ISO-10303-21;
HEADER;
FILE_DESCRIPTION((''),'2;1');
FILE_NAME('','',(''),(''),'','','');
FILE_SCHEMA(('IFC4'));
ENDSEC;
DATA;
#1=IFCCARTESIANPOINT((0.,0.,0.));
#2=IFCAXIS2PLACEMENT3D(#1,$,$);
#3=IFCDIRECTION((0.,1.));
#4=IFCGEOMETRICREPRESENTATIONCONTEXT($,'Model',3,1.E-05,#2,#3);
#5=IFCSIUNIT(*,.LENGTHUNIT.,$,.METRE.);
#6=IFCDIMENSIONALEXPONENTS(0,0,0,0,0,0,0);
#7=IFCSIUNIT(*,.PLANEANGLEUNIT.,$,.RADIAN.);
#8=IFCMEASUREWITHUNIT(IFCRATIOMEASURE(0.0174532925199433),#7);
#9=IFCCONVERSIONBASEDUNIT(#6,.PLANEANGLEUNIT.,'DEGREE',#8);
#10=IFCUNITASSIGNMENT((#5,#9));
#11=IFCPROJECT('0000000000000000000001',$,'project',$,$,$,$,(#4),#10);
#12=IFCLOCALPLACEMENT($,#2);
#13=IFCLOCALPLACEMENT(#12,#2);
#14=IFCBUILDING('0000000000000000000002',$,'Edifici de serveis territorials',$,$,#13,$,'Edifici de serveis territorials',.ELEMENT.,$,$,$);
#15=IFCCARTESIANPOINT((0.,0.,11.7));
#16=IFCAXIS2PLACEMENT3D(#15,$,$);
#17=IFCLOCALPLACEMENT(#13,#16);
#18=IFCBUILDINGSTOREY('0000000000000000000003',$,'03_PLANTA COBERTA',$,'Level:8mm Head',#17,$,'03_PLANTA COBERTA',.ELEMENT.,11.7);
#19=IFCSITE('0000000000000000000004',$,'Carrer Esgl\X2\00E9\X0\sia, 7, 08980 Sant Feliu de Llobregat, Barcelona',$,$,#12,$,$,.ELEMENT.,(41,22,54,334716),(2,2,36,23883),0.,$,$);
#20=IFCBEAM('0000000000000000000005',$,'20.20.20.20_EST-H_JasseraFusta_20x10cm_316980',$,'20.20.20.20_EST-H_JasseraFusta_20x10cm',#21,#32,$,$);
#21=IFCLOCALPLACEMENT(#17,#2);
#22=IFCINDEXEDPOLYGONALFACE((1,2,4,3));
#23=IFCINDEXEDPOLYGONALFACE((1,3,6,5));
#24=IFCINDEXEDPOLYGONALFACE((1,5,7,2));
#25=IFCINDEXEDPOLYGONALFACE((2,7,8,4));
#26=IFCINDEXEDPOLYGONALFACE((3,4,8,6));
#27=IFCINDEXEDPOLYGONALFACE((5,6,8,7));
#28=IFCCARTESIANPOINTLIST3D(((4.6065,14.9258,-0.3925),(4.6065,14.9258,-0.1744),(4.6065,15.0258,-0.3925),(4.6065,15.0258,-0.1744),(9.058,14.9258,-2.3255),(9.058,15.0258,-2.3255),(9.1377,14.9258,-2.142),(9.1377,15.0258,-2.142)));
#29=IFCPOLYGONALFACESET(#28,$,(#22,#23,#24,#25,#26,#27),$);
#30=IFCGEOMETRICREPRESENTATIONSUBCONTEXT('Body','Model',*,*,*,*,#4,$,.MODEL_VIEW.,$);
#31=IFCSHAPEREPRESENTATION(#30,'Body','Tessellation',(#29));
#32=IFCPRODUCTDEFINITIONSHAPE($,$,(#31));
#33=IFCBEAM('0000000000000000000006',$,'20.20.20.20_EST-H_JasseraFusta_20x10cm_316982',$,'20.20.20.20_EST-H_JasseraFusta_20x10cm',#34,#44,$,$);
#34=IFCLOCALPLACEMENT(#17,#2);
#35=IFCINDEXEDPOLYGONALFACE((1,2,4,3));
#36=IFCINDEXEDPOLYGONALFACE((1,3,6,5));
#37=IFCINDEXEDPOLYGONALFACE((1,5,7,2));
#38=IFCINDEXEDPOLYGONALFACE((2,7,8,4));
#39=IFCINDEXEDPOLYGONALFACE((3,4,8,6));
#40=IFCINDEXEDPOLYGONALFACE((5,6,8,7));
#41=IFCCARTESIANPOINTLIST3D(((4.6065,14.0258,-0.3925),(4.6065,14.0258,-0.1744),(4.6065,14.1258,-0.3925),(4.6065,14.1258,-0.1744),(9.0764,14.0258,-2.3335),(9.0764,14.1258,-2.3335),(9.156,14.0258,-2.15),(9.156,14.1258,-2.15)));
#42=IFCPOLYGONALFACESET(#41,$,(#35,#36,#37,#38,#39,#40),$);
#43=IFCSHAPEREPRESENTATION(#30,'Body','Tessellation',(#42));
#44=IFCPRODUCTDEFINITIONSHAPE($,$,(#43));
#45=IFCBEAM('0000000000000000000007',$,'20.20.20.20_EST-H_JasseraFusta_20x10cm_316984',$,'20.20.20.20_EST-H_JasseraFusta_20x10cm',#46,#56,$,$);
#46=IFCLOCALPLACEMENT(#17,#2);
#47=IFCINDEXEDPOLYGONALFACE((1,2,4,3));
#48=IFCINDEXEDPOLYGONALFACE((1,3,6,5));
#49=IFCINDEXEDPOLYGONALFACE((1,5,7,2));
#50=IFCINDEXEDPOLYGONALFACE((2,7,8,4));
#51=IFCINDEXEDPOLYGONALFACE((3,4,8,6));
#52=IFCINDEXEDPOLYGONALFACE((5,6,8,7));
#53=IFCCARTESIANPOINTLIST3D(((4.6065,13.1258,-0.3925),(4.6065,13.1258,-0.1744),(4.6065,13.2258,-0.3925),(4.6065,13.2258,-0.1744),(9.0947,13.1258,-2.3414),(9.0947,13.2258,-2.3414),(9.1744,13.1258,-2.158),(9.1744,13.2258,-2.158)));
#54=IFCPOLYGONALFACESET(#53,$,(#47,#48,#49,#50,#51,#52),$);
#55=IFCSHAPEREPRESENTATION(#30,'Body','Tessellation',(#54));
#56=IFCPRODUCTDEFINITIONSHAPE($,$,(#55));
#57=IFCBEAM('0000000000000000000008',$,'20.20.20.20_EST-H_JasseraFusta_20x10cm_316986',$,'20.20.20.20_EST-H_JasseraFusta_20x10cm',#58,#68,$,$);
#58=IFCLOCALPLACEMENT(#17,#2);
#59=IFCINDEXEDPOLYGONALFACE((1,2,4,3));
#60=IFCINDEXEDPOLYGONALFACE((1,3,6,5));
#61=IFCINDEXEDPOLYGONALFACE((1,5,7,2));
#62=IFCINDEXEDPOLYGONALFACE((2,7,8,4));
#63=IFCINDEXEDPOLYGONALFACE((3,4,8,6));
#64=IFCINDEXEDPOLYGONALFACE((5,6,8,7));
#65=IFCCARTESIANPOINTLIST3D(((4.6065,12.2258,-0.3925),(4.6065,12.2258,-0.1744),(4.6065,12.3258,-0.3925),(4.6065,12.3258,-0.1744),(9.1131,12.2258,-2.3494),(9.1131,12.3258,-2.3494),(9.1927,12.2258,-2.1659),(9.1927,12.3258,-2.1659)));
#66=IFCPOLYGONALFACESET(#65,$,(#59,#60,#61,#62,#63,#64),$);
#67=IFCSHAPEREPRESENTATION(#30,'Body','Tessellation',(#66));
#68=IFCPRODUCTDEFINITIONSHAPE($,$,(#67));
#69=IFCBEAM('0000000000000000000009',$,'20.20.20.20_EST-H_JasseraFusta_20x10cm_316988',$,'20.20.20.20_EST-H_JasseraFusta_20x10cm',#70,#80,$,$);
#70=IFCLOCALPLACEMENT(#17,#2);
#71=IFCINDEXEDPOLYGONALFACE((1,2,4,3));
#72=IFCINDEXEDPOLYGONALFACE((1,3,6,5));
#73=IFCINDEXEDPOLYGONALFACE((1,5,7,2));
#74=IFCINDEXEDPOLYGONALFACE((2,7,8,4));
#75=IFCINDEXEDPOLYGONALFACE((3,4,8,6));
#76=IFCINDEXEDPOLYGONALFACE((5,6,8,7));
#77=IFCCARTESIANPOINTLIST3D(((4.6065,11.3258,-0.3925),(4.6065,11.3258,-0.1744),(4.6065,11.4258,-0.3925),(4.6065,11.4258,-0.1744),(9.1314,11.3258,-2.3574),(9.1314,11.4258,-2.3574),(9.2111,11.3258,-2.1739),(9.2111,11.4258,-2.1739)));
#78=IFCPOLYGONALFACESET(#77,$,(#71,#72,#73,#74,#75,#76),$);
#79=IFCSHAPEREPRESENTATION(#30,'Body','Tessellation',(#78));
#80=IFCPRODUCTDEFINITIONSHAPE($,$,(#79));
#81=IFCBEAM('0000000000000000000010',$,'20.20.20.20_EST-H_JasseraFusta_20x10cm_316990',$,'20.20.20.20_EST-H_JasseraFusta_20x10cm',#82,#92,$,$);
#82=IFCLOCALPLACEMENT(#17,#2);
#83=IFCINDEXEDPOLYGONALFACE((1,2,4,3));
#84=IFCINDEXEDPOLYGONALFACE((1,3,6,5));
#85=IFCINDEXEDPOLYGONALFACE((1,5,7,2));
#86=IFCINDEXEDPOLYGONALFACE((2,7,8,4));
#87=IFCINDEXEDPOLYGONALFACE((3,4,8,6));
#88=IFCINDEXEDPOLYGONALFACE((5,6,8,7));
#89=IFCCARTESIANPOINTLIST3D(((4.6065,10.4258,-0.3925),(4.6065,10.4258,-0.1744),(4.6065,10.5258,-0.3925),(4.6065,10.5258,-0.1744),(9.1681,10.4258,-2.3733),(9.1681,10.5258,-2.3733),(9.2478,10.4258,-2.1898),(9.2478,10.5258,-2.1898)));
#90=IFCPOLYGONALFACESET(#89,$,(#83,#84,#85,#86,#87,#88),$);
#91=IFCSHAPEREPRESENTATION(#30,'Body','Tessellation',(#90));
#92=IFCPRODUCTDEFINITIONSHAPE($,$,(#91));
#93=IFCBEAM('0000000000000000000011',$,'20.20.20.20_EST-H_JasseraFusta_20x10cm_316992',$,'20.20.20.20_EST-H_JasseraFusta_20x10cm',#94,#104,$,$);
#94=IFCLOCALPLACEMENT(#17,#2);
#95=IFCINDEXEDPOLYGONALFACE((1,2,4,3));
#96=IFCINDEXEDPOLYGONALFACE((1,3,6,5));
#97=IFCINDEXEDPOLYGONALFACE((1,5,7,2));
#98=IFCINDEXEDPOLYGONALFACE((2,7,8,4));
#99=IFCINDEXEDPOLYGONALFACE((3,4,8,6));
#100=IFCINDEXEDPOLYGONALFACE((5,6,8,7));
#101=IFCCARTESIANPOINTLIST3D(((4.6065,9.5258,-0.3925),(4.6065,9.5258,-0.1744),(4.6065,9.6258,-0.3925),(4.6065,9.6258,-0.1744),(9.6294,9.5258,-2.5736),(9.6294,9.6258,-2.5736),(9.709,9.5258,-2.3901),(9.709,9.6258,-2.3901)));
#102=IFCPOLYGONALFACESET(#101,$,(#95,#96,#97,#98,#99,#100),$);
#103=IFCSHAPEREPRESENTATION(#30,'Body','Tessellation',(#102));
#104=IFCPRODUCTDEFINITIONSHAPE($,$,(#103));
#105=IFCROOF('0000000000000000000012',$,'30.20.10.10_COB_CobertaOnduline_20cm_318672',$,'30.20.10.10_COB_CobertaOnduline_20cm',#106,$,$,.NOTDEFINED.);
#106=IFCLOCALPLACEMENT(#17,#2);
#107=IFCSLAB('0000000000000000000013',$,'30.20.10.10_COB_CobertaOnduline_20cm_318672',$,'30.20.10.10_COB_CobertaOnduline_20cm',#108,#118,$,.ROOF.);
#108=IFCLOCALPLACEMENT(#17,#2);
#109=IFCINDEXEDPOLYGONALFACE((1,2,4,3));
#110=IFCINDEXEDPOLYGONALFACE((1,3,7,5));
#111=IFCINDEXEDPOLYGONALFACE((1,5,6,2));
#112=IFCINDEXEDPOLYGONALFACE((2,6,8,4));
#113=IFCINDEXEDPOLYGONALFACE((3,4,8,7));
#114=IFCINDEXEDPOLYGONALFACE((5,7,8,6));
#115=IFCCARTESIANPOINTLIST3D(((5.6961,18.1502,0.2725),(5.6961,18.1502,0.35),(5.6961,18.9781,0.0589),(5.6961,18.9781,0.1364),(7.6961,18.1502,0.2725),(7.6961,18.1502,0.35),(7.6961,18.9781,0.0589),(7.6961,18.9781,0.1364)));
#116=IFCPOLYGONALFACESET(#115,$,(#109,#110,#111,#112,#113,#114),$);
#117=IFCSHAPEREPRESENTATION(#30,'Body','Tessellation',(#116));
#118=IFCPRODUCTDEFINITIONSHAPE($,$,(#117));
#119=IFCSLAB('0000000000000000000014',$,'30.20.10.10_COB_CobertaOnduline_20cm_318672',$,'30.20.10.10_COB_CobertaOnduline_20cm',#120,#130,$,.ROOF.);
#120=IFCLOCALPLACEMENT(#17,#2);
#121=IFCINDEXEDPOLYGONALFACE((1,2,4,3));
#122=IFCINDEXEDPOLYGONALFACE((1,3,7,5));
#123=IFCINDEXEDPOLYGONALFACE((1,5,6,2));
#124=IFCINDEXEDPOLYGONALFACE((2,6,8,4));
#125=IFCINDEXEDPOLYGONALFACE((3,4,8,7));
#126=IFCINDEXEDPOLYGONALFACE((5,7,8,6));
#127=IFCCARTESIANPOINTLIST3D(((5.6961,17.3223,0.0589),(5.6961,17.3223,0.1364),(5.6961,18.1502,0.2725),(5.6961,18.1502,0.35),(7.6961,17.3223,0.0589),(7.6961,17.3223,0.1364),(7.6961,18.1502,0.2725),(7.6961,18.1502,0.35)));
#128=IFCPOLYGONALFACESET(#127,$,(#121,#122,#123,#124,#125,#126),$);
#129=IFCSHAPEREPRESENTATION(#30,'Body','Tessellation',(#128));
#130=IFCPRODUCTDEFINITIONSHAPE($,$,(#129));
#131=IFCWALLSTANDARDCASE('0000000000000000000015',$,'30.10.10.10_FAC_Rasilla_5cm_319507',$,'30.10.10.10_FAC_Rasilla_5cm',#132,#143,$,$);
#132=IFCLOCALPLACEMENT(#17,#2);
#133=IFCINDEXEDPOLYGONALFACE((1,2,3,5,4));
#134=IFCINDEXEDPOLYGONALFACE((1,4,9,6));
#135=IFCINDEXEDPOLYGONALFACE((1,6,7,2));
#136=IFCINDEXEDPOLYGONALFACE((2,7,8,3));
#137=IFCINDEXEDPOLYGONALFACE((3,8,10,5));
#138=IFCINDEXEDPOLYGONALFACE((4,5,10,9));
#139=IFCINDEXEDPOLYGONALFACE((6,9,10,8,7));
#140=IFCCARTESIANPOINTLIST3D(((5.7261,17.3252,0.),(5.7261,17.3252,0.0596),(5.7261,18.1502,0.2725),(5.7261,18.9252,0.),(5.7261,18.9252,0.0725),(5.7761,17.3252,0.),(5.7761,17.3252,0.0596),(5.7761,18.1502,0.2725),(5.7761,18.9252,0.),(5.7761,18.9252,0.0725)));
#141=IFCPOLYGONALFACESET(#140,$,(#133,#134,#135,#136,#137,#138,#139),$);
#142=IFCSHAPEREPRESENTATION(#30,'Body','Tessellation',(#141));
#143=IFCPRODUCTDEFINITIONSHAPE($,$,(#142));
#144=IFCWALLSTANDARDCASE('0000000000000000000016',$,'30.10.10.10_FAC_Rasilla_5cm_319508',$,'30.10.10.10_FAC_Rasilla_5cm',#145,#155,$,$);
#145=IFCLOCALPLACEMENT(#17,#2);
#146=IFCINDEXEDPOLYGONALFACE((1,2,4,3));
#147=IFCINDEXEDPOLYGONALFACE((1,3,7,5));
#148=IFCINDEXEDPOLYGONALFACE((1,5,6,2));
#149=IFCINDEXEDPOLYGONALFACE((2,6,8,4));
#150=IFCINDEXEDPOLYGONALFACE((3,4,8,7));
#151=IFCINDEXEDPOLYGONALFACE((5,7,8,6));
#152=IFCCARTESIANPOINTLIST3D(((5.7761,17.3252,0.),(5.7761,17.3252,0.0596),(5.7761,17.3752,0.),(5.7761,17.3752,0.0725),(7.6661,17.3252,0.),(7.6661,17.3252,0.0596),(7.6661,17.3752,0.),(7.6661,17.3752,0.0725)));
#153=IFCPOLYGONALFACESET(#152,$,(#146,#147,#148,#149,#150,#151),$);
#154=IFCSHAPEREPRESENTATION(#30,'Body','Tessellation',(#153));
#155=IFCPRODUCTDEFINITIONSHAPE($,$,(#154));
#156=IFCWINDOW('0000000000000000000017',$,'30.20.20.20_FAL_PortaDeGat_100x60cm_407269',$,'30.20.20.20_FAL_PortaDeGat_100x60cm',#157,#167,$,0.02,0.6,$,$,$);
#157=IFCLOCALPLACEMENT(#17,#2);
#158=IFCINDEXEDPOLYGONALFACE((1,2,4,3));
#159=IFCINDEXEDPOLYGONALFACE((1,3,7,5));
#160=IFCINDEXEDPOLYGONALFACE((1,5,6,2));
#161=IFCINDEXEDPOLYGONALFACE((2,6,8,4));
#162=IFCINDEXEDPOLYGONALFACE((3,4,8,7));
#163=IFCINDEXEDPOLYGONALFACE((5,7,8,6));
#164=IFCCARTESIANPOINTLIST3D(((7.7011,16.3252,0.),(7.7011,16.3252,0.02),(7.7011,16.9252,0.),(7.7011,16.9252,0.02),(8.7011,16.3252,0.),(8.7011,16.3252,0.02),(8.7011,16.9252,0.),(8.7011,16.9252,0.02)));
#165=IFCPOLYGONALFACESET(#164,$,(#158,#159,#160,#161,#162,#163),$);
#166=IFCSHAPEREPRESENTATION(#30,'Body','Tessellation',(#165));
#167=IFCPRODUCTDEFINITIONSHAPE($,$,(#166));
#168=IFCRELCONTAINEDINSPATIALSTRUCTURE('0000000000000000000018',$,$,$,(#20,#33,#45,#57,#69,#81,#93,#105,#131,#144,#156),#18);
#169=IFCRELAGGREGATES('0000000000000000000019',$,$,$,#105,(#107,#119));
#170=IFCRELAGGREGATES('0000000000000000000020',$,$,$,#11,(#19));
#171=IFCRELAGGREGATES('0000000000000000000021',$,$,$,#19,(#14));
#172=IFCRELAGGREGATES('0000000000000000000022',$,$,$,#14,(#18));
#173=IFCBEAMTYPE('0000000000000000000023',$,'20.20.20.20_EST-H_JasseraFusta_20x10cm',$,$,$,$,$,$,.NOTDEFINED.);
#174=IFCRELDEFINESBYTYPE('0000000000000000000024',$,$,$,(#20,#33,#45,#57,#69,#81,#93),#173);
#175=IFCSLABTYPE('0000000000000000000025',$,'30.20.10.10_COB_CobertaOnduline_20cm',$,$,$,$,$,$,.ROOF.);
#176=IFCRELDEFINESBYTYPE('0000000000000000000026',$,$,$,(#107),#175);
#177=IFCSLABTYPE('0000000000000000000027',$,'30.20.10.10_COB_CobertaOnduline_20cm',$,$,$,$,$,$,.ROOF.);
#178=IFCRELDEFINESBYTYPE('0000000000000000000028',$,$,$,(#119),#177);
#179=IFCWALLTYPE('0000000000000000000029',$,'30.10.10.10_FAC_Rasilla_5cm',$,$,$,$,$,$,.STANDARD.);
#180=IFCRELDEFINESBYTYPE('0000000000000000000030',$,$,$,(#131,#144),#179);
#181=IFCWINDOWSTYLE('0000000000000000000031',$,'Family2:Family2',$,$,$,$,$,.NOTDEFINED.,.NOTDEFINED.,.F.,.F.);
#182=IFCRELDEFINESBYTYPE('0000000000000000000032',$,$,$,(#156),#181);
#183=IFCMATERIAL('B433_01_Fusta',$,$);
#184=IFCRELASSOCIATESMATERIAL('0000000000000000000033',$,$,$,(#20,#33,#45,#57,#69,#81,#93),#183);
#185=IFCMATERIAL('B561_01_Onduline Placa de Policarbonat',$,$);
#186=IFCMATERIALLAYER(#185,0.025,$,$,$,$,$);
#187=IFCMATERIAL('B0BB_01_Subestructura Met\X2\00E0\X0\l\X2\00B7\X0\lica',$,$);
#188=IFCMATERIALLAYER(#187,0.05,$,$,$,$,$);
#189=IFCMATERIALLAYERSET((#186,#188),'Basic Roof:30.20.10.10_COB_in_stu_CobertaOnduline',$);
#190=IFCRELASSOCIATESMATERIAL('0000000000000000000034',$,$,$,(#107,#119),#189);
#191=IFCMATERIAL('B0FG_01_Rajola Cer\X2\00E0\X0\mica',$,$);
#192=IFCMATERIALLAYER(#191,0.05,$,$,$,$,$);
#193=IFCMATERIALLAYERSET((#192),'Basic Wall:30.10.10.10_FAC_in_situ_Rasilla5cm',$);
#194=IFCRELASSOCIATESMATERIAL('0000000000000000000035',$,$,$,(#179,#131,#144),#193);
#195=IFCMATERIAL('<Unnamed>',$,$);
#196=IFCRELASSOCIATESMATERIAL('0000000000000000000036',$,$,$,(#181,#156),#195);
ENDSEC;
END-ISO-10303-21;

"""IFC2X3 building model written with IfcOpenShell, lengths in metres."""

from ifc_helpers import new_model, entity, si_unit, converted_unit, direction, frame, frame_2d, origin, origin_2d_with_axis, place, context, subcontext, project, spatial, polyline, rectangle, extrude, clip, halfspace, bounded_halfspace, source, transform, mapped, material, layer, layer_set, layer_usage, type_object, type_shapes, element, aggregate, save


model = new_model("IFC2X3")

# Units and contexts
model_context = context("Model", 3, precision=1e-05, world=origin(), true_north=direction((0.0, 1.0)))
body_context = subcontext(model_context, "Body", "Model", "MODEL_VIEW")
ifc_project = project(units=[si_unit("LENGTHUNIT", "METRE"), converted_unit("PLANEANGLEUNIT", "DEGREE", entity("IfcRatioMeasure", 0.0174532925199433), si_unit("PLANEANGLEUNIT", "RADIAN"), dimensions=[0, 0, 0, 0, 0, 0, 0])], contexts=[model_context])

# Site, building, storey
site_placement = place(None, origin())
site = spatial("IfcSite", under=ifc_project, at=site_placement, Name="Carrer Església, 7, 08980 Sant Feliu de Llobregat, Barcelona", CompositionType="ELEMENT", RefLatitude=(41, 22, 54, 334716), RefLongitude=(2, 2, 36, 23883), RefElevation=0.0)
building_placement = place(site_placement, origin())
building = spatial("IfcBuilding", under=site, at=building_placement, Name="Edifici de serveis territorials", LongName="Edifici de serveis territorials", CompositionType="ELEMENT")
storey_placement = place(building_placement, frame((0.0, 0.0, 11.7)))
storey = spatial("IfcBuildingStorey", under=building, at=storey_placement, Name="03_PLANTA COBERTA", ObjectType="Level:8mm Head", LongName="03_PLANTA COBERTA", CompositionType="ELEMENT", Elevation=11.7)

# Beams
ifc_material_1 = material(Name="B433_01_Fusta")
beam_type = type_object("IfcBeamType", Name="20.20.20.20_EST-H_JasseraFusta_20x10cm", PredefinedType="NOTDEFINED")
beam_1_placement = place(storey_placement, frame((4.6065, 14.9758, -0.1744), z_axis=(0.3983, 0.0, 0.917255), x_axis=(0.917255, 0.0, -0.3983)))
element("IfcBeam", 1, at=beam_1_placement, inside=storey, type_object=beam_type, material=ifc_material_1, Name="20.20.20.20_EST-H_JasseraFusta_20x10cm_316980", ObjectType="20.20.20.20_EST-H_JasseraFusta_20x10cm", context=body_context, shape_type="Clipping", body=[
    clip(extrude(rectangle(XDim=0.2, YDim=0.1, at=frame_2d((0.0, 0.0), x_axis=(1.0, 0.0))), frame((0.0, 0.0, -0.1), z_axis=(1.0, 0.0, 0.0), x_axis=(0.0, 0.0, -1.0)), (0.0, 0.0, 1.0), 4.94), halfspace(frame((0.0868, 0.0, -0.2), z_axis=(-0.917255, 0.0, -0.3983), x_axis=(0.0, 1.0, 0.0)), False)),
])
beam_2_placement = place(storey_placement, frame((4.6065, 14.0758, -0.1744), z_axis=(0.3983, 0.0, 0.917255), x_axis=(0.917255, 0.0, -0.3983)))
element("IfcBeam", 2, at=beam_2_placement, inside=storey, type_object=beam_type, material=ifc_material_1, Name="20.20.20.20_EST-H_JasseraFusta_20x10cm_316982", ObjectType="20.20.20.20_EST-H_JasseraFusta_20x10cm", context=body_context, shape_type="Clipping", body=[
    clip(extrude(rectangle(XDim=0.2, YDim=0.1, at=frame_2d((0.0, 0.0), x_axis=(1.0, 0.0))), frame((0.0, 0.0, -0.1), z_axis=(1.0, 0.0, 0.0), x_axis=(0.0, 0.0, -1.0)), (0.0, 0.0, 1.0), 4.96), halfspace(frame((0.0868, 0.0, -0.2), z_axis=(-0.917255, 0.0, -0.3983), x_axis=(0.0, 1.0, 0.0)), False)),
])
beam_3_placement = place(storey_placement, frame((4.6065, 13.1758, -0.1744), z_axis=(0.3983, 0.0, 0.917255), x_axis=(0.917255, 0.0, -0.3983)))
element("IfcBeam", 3, at=beam_3_placement, inside=storey, type_object=beam_type, material=ifc_material_1, Name="20.20.20.20_EST-H_JasseraFusta_20x10cm_316984", ObjectType="20.20.20.20_EST-H_JasseraFusta_20x10cm", context=body_context, shape_type="Clipping", body=[
    clip(extrude(rectangle(XDim=0.2, YDim=0.1, at=origin_2d_with_axis()), frame((0.0, 0.0, -0.1), z_axis=(1.0, 0.0, 0.0), x_axis=(0.0, 0.0, -1.0)), (0.0, 0.0, 1.0), 4.98), halfspace(frame((0.0868, 0.0, -0.2), z_axis=(-0.917255, 0.0, -0.3983), x_axis=(0.0, 1.0, 0.0)), False)),
])
beam_4_placement = place(storey_placement, frame((4.6065, 12.2758, -0.1744), z_axis=(0.3983, 0.0, 0.917255), x_axis=(0.917255, 0.0, -0.3983)))
element("IfcBeam", 4, at=beam_4_placement, inside=storey, type_object=beam_type, material=ifc_material_1, Name="20.20.20.20_EST-H_JasseraFusta_20x10cm_316986", ObjectType="20.20.20.20_EST-H_JasseraFusta_20x10cm", context=body_context, shape_type="Clipping", body=[
    clip(extrude(rectangle(XDim=0.2, YDim=0.1, at=frame_2d((0.0, 0.0), x_axis=(1.0, 0.0))), frame((0.0, 0.0, -0.1), z_axis=(1.0, 0.0, 0.0), x_axis=(0.0, 0.0, -1.0)), (0.0, 0.0, 1.0), 5.0), halfspace(frame((0.0868, 0.0, -0.2), z_axis=(-0.917255, 0.0, -0.3983), x_axis=(0.0, 1.0, 0.0)), False)),
])
beam_5_placement = place(storey_placement, frame((4.6065, 11.3758, -0.1744), z_axis=(0.3983, 0.0, 0.917255), x_axis=(0.917255, 0.0, -0.3983)))
element("IfcBeam", 5, at=beam_5_placement, inside=storey, type_object=beam_type, material=ifc_material_1, Name="20.20.20.20_EST-H_JasseraFusta_20x10cm_316988", ObjectType="20.20.20.20_EST-H_JasseraFusta_20x10cm", context=body_context, shape_type="Clipping", body=[
    clip(extrude(rectangle(XDim=0.2, YDim=0.1, at=origin_2d_with_axis()), frame((0.0, 0.0, -0.1), z_axis=(1.0, 0.0, 0.0), x_axis=(0.0, 0.0, -1.0)), (0.0, 0.0, 1.0), 5.02), halfspace(frame((0.0868, 0.0, -0.2), z_axis=(-0.917255, 0.0, -0.3983), x_axis=(0.0, 1.0, 0.0)), False)),
])
beam_6_placement = place(storey_placement, frame((4.6065, 10.4758, -0.1744), z_axis=(0.3983, 0.0, 0.917255), x_axis=(0.917255, 0.0, -0.3983)))
element("IfcBeam", 6, at=beam_6_placement, inside=storey, type_object=beam_type, material=ifc_material_1, Name="20.20.20.20_EST-H_JasseraFusta_20x10cm_316990", ObjectType="20.20.20.20_EST-H_JasseraFusta_20x10cm", context=body_context, shape_type="Clipping", body=[
    clip(extrude(rectangle(XDim=0.2, YDim=0.1, at=frame_2d((0.0, 0.0), x_axis=(1.0, 0.0))), frame((0.0, 0.0, -0.1), z_axis=(1.0, 0.0, 0.0), x_axis=(0.0, 0.0, -1.0)), (0.0, 0.0, 1.0), 5.06), halfspace(frame((0.0868, 0.0, -0.2), z_axis=(-0.917255, 0.0, -0.3983), x_axis=(0.0, 1.0, 0.0)), False)),
])
beam_7_placement = place(storey_placement, frame((4.6065, 9.5758, -0.1744), z_axis=(0.3983, 0.0, 0.917255), x_axis=(0.917255, 0.0, -0.3983)))
element("IfcBeam", 7, at=beam_7_placement, inside=storey, type_object=beam_type, material=ifc_material_1, Name="20.20.20.20_EST-H_JasseraFusta_20x10cm_316992", ObjectType="20.20.20.20_EST-H_JasseraFusta_20x10cm", context=body_context, shape_type="Clipping", body=[
    clip(extrude(rectangle(XDim=0.2, YDim=0.1, at=frame_2d((0.0, 0.0), x_axis=(1.0, 0.0))), frame((0.0, 0.0, -0.1), z_axis=(1.0, 0.0, 0.0), x_axis=(0.0, 0.0, -1.0)), (0.0, 0.0, 1.0), 5.5629), halfspace(frame((0.0868, 0.0, -0.2), z_axis=(-0.917255, 0.0, -0.3983), x_axis=(0.0, 1.0, 0.0)), False)),
])

# Shared definitions
ifc_material_2 = material(Name="B0FG_01_Rajola Ceràmica")

# Roof, slabs
roof_1_placement = place(storey_placement, frame((5.6961, 17.3223, 0.0589)))
roof_1 = element("IfcRoof", 8, at=roof_1_placement, inside=storey, Name="30.20.10.10_COB_CobertaOnduline_20cm_318672", ObjectType="30.20.10.10_COB_CobertaOnduline_20cm", ShapeType="NOTDEFINED")
ifc_material_3 = material(Name="B561_01_Onduline Placa de Policarbonat")
ifc_layer_1 = layer(ifc_material_3, 0.025)
ifc_material_4 = material(Name="B0BB_01_Subestructura Metàl·lica")
ifc_layer_2 = layer(ifc_material_4, 0.05)
ifc_layer_set_1 = layer_set([ifc_layer_1, ifc_layer_2], Name="Basic Roof:30.20.10.10_COB_in_stu_CobertaOnduline")
slab_type_1 = type_object("IfcSlabType", Name="30.20.10.10_COB_CobertaOnduline_20cm", PredefinedType="ROOF")
slab_1_placement = place(roof_1_placement, origin())
slab_1 = element("IfcSlab", 9, at=slab_1_placement, type_object=slab_type_1, material=ifc_layer_set_1, Name="30.20.10.10_COB_CobertaOnduline_20cm_318672", ObjectType="30.20.10.10_COB_CobertaOnduline_20cm", PredefinedType="ROOF", context=body_context, shape_type="SweptSolid", body=[
    extrude(rectangle(XDim=2.0, YDim=0.855, at=frame_2d((0.0, 0.0), x_axis=(1.0, 0.0))), frame((1.0, 1.2418, 0.1068), z_axis=(0.0, 0.249878, 0.968277), x_axis=(1.0, 0.0, 0.0)), (0.0, -0.249878, 0.968277), 0.0775),
])
slab_type_2 = type_object("IfcSlabType", Name="30.20.10.10_COB_CobertaOnduline_20cm", PredefinedType="ROOF")
slab_2_placement = place(roof_1_placement, origin())
slab_2 = element("IfcSlab", 10, at=slab_2_placement, type_object=slab_type_2, material=ifc_layer_set_1, Name="30.20.10.10_COB_CobertaOnduline_20cm_318672", ObjectType="30.20.10.10_COB_CobertaOnduline_20cm", PredefinedType="ROOF", context=body_context, shape_type="SweptSolid", body=[
    extrude(rectangle(XDim=2.0, YDim=0.855, at=frame_2d((0.0, 0.0), x_axis=(1.0, 0.0))), frame((1.0, 0.4139, 0.1068), z_axis=(0.0, -0.249878, 0.968277), x_axis=(1.0, 0.0, 0.0)), (0.0, 0.249878, 0.968277), 0.0775),
])
aggregate(roof_1, [slab_1, slab_2])

# Walls
ifc_layer_3 = layer(ifc_material_2, 0.05)
ifc_layer_set_2 = layer_set([ifc_layer_3], Name="Basic Wall:30.10.10.10_FAC_in_situ_Rasilla5cm")
ifc_layer_usage_1 = layer_usage(ifc_layer_set_2, "AXIS2", "NEGATIVE", 0.025)
wall_type = type_object("IfcWallType", Name="30.10.10.10_FAC_Rasilla_5cm", PredefinedType="STANDARD", material=ifc_layer_set_2)
wall_1_placement = place(storey_placement, frame((5.7511, 17.3252, 0.0), z_axis=(0.0, 0.0, 1.0), x_axis=(0.0, 1.0, 0.0)))
element("IfcWallStandardCase", 11, at=wall_1_placement, inside=storey, type_object=wall_type, material=ifc_layer_usage_1, Name="30.10.10.10_FAC_Rasilla_5cm_319507", ObjectType="30.10.10.10_FAC_Rasilla_5cm", context=body_context, shape_type="Clipping", body=[
    clip(clip(extrude(rectangle(XDim=1.6, YDim=0.05, at=frame_2d((0.8, 0.0), x_axis=(-1.0, 0.0))), origin(), (0.0, 0.0, 1.0), 0.2725), bounded_halfspace(frame((0.825, -0.025, 0.2725), z_axis=(-0.249878, 0.0, -0.968277), x_axis=(0.0, -1.0, 0.0)), True, frame((0.825, -0.025, 0.2725)), polyline([(0.0, 0.0), (0.775, 0.0), (0.775, 0.05), (0.0, 0.05), (0.0, 0.0)]))), bounded_halfspace(frame((0.0, -0.025, 0.0596), z_axis=(0.249878, 0.0, -0.968277), x_axis=(0.0, -1.0, 0.0)), True, frame((0.0, -0.025, 0.0596)), polyline([(0.0, 0.0), (0.05, 0.0), (0.825, 0.0), (0.825, 0.05), (0.0, 0.05), (0.0, 0.0)]))),
])
ifc_layer_usage_2 = layer_usage(ifc_layer_set_2, "AXIS2", "NEGATIVE", 0.025)
wall_2_placement = place(storey_placement, frame((7.6661, 17.3502, 0.0), z_axis=(0.0, 0.0, 1.0), x_axis=(-1.0, 0.0, 0.0)))
element("IfcWallStandardCase", 12, at=wall_2_placement, inside=storey, type_object=wall_type, material=ifc_layer_usage_2, Name="30.10.10.10_FAC_Rasilla_5cm_319508", ObjectType="30.10.10.10_FAC_Rasilla_5cm", context=body_context, shape_type="Clipping", body=[
    clip(extrude(rectangle(XDim=1.89, YDim=0.05, at=frame_2d((0.945, 0.0), x_axis=(-1.0, 0.0))), origin(), (0.0, 0.0, 1.0), 0.0725), bounded_halfspace(frame((0.0, -0.025, 0.0725), z_axis=(0.0, -0.249878, -0.968277), x_axis=(-1.0, 0.0, 0.0)), True, frame((0.0, -0.025, 0.0725)), polyline([(0.0, 0.0), (0.05, 0.0), (1.89, 0.0), (1.89, 0.05), (0.0, 0.05), (0.0, 0.0)]))),
])

# Window
ifc_material_5 = material(Name="<Unnamed>")
window_style = type_object("IfcWindowStyle", Name="Family2:Family2", ConstructionType="NOTDEFINED", OperationType="NOTDEFINED", ParameterTakesPrecedence=False, Sizeable=False, material=ifc_material_5)
shared_shape_1 = source(origin(), body_context, "Body", "SweptSolid", [
    extrude(rectangle(XDim=0.6, YDim=1.0, at=origin_2d_with_axis()), frame((0.3, -0.5, 0.0), z_axis=(0.0, 0.0, 1.0), x_axis=(-1.0, 0.0, 0.0)), (0.0, 0.0, 1.0), 0.02),
])
type_shapes(window_style, [shared_shape_1])
window_placement = place(storey_placement, frame((7.7011, 16.3252, 0.0), z_axis=(0.0, 0.0, 1.0), x_axis=(0.0, 1.0, 0.0)))
element("IfcWindow", 13, at=window_placement, inside=storey, type_object=window_style, material=ifc_material_5, Name="30.20.20.20_FAL_PortaDeGat_100x60cm_407269", ObjectType="30.20.20.20_FAL_PortaDeGat_100x60cm", OverallHeight=0.02, OverallWidth=0.6, context=body_context, shape_type="MappedRepresentation", body=[
    mapped(shared_shape_1, transform((0.0, 0.0, 0.0), scale=1.0)),
])

save(model, "model.ifc")
